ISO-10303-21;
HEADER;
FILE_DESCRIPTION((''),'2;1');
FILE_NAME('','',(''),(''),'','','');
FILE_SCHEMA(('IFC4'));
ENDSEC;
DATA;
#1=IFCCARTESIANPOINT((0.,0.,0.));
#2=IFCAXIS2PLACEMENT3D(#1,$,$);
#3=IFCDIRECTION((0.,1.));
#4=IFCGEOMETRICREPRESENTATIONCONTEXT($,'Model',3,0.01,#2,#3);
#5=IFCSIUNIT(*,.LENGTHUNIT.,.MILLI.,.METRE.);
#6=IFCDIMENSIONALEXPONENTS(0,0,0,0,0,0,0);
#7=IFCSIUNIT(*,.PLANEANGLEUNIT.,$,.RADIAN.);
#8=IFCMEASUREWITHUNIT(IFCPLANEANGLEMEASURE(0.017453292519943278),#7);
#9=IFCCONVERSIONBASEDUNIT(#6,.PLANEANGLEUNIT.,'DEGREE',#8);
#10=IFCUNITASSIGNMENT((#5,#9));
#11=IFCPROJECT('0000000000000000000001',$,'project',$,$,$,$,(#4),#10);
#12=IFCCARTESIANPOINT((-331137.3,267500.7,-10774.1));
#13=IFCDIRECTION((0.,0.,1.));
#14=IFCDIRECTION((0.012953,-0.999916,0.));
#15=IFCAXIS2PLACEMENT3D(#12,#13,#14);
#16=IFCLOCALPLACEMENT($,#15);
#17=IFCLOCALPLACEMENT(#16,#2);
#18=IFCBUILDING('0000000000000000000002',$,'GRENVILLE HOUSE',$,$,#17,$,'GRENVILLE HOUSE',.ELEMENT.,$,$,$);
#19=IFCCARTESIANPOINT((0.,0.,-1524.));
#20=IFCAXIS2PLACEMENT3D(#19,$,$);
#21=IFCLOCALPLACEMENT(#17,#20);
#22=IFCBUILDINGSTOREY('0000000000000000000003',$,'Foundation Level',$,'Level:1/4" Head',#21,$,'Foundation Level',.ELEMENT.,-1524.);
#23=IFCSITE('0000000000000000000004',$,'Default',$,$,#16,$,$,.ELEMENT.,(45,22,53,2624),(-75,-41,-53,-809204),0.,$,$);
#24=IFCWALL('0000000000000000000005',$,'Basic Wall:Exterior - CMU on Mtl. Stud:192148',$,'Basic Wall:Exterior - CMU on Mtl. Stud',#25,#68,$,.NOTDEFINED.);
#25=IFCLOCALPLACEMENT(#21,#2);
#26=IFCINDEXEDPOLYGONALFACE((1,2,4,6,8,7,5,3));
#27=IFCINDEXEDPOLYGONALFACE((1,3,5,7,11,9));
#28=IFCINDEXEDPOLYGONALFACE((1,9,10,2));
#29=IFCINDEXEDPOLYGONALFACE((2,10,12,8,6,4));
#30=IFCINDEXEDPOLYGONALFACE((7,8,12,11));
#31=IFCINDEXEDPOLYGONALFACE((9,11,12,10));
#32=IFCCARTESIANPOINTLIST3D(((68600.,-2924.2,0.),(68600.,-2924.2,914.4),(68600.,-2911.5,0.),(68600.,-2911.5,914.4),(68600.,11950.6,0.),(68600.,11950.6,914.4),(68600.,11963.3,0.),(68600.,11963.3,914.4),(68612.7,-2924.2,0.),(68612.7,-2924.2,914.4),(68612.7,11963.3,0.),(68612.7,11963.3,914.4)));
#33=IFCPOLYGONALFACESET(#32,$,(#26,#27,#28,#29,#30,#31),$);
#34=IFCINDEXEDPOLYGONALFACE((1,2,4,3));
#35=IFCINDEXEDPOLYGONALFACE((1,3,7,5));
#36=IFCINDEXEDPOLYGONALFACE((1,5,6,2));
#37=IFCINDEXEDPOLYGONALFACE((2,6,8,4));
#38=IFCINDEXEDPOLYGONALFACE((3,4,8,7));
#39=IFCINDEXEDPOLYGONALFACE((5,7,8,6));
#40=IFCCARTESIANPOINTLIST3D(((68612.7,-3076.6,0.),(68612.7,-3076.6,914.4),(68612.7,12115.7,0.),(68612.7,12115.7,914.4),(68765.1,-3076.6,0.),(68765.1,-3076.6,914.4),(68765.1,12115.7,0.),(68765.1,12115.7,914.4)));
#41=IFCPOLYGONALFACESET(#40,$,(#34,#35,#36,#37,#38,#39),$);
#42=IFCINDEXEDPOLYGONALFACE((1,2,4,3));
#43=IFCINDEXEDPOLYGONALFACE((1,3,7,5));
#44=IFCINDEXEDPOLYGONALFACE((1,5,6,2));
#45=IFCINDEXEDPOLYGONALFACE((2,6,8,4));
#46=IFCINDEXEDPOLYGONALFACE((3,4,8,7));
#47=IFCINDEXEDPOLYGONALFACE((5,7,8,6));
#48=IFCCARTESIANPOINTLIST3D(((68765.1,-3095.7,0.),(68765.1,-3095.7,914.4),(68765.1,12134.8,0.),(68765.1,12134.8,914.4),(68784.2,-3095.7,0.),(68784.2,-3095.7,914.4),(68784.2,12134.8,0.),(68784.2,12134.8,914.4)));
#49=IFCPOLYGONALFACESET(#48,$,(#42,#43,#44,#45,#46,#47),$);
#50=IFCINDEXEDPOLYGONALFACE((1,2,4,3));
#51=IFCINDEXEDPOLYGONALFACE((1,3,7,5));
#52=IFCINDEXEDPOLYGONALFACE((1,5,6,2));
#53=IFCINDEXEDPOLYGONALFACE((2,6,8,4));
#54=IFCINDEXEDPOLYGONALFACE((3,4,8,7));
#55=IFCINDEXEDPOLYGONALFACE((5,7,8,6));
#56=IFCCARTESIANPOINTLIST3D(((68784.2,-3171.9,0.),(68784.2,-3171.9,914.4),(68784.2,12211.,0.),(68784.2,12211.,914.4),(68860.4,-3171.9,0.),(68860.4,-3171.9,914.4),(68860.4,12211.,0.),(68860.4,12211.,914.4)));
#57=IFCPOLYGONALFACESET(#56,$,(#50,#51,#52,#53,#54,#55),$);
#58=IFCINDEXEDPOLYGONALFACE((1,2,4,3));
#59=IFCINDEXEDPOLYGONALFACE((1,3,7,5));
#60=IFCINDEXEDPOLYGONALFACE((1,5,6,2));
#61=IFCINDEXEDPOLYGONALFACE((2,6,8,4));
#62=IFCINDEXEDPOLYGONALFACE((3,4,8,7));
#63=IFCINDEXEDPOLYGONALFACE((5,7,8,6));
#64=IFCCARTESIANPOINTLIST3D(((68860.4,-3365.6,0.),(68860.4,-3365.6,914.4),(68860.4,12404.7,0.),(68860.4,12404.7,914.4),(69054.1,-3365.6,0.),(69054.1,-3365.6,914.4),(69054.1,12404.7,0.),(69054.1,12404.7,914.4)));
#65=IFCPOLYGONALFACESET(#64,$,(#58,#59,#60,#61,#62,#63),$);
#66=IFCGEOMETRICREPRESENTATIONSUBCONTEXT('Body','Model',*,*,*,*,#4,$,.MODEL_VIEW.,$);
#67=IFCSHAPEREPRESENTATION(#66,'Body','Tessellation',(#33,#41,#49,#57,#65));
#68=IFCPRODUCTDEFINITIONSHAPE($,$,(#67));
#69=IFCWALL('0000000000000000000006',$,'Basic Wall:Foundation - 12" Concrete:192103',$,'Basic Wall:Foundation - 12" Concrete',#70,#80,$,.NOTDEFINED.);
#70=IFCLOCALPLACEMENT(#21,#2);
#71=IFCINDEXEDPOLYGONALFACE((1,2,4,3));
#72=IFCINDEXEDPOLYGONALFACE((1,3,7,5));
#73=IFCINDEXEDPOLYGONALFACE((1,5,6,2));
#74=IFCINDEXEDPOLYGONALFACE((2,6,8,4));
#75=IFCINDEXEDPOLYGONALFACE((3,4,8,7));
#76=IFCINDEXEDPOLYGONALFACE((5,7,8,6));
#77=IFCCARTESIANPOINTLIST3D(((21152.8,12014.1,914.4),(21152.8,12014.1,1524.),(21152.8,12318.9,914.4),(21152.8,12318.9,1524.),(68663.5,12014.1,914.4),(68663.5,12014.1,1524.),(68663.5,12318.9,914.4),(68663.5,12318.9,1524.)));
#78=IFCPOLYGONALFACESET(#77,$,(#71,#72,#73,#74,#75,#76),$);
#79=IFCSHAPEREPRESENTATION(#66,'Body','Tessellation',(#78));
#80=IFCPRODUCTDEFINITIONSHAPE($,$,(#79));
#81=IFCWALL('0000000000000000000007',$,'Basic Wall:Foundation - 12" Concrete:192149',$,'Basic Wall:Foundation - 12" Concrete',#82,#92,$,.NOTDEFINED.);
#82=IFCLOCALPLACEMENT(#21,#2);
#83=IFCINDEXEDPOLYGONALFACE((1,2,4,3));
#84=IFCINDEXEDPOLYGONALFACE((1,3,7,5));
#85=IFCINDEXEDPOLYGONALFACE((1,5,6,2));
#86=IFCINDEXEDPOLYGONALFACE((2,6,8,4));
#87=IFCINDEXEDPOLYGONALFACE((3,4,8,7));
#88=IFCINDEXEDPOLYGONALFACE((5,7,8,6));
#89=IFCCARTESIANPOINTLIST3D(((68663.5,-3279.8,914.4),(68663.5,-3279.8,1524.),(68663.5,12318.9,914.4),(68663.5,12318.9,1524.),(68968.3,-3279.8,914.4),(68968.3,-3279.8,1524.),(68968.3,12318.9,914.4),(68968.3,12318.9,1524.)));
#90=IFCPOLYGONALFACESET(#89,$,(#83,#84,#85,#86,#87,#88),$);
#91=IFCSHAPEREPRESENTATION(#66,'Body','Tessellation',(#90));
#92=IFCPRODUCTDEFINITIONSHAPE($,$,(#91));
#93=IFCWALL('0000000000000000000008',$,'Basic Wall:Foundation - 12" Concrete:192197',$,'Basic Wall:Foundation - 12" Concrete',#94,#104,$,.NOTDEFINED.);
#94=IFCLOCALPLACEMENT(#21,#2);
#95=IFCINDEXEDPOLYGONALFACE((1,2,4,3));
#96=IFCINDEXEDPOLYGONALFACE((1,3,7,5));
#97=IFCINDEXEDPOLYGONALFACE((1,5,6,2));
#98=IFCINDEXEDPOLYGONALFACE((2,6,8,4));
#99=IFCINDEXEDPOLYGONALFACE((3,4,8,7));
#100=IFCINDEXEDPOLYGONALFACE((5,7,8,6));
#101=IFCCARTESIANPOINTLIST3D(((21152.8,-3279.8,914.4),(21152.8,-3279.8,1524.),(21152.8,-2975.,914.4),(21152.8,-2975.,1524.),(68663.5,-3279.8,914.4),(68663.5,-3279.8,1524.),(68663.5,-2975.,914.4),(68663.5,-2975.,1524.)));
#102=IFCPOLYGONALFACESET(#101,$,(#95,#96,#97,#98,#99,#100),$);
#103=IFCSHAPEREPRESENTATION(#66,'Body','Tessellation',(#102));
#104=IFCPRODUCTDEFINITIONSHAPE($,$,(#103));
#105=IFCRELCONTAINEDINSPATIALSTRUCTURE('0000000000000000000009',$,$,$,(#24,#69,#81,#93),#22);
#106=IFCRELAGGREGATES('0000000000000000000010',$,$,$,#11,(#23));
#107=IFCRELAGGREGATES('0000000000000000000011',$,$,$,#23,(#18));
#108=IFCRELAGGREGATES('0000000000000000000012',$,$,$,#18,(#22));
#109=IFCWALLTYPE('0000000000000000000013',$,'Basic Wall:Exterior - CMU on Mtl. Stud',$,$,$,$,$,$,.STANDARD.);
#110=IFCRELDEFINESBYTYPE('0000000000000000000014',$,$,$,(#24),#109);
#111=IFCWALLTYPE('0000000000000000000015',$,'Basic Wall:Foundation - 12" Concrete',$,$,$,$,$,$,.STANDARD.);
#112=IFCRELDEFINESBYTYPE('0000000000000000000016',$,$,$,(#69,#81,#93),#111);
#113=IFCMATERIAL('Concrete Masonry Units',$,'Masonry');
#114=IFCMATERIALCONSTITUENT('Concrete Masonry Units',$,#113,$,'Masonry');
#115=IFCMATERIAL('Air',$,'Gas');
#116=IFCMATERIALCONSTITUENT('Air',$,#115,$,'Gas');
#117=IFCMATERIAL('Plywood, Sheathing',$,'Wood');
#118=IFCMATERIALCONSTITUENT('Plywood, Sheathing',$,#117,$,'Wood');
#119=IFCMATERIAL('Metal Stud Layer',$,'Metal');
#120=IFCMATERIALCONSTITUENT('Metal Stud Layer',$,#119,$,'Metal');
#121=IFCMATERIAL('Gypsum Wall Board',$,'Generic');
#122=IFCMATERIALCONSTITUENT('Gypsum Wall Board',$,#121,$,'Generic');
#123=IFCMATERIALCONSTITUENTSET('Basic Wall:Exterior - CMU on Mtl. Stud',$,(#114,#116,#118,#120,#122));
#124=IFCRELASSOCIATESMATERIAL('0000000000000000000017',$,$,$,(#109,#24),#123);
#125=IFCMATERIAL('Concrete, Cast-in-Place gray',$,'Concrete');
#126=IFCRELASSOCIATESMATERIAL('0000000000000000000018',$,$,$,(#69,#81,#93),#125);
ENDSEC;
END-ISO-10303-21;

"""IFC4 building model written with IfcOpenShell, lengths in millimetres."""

from ifc_helpers import new_model, entity, si_unit, converted_unit, direction, frame, origin, place, context, subcontext, project, spatial, indexed_curve, outline, extrude, material, constituent, constituent_set, type_object, element, save


model = new_model("IFC4")

# Units and contexts
model_context = context("Model", 3, precision=0.01, world=origin(), true_north=direction((0.0, 1.0)))
body_context = subcontext(model_context, "Body", "Model", "MODEL_VIEW")
ifc_project = project(units=[si_unit("LENGTHUNIT", "METRE", prefix="MILLI"), converted_unit("PLANEANGLEUNIT", "DEGREE", entity("IfcPlaneAngleMeasure", 0.017453292519943278), si_unit("PLANEANGLEUNIT", "RADIAN"), dimensions=[0, 0, 0, 0, 0, 0, 0])], contexts=[model_context])

# Site, building, storey
site_placement = place(None, frame((-331137.3, 267500.7, -10774.1), z_axis=(0.0, 0.0, 1.0), x_axis=(0.012953, -0.999916, 0.0)))
site = spatial("IfcSite", under=ifc_project, at=site_placement, Name="Default", CompositionType="ELEMENT", RefLatitude=(45, 22, 53, 2624), RefLongitude=(-75, -41, -53, -809204), RefElevation=0.0)
building_placement = place(site_placement, origin())
building = spatial("IfcBuilding", under=site, at=building_placement, Name="GRENVILLE HOUSE", LongName="GRENVILLE HOUSE", CompositionType="ELEMENT")
storey_placement = place(building_placement, frame((0.0, 0.0, -1524.0)))
storey = spatial("IfcBuildingStorey", under=building, at=storey_placement, Name="Foundation Level", ObjectType="Level:1/4\" Head", LongName="Foundation Level", CompositionType="ELEMENT", Elevation=-1524.0)

# Shared definitions
ifc_material_1 = material(Name="Concrete, Cast-in-Place gray", Category="Concrete")

# Shared definitions
ifc_material_2 = material(Name="Concrete Masonry Units", Category="Masonry")
ifc_constituent_1 = constituent(ifc_material_2, Name="Concrete Masonry Units", Category="Masonry")
ifc_material_3 = material(Name="Air", Category="Gas")
ifc_constituent_2 = constituent(ifc_material_3, Name="Air", Category="Gas")
ifc_material_4 = material(Name="Plywood, Sheathing", Category="Wood")
ifc_constituent_3 = constituent(ifc_material_4, Name="Plywood, Sheathing", Category="Wood")
ifc_material_5 = material(Name="Metal Stud Layer", Category="Metal")
ifc_constituent_4 = constituent(ifc_material_5, Name="Metal Stud Layer", Category="Metal")
ifc_material_6 = material(Name="Gypsum Wall Board", Category="Generic")
ifc_constituent_5 = constituent(ifc_material_6, Name="Gypsum Wall Board", Category="Generic")
ifc_constituent_set = constituent_set(constituents=[ifc_constituent_1, ifc_constituent_2, ifc_constituent_3, ifc_constituent_4, ifc_constituent_5], Name="Basic Wall:Exterior - CMU on Mtl. Stud")
wall_type_1 = type_object("IfcWallType", Name="Basic Wall:Exterior - CMU on Mtl. Stud", PredefinedType="STANDARD", material=ifc_constituent_set)

# Walls
wall_1_placement = place(storey_placement, frame((68827.0, 12404.7, 0.0), z_axis=(0.0, 0.0, 1.0), x_axis=(0.0, -1.0, 0.0)))
element("IfcWall", 1, at=wall_1_placement, inside=storey, type_object=wall_type_1, material=ifc_constituent_set, Name="Basic Wall:Exterior - CMU on Mtl. Stud:192148", ObjectType="Basic Wall:Exterior - CMU on Mtl. Stud", PredefinedType="NOTDEFINED", context=body_context, shape_type="SweptSolid", body=[
    extrude(outline(indexed_curve([(-7431.1, -4.2), (7431.1, -4.2), (7443.8, -4.2), (7443.8, 8.5), (-7443.8, 8.5), (-7443.8, -4.2), (-7431.1, -4.2)], self_intersect=False)), frame((7885.1, -222.8, 0.0)), (0.0, 0.0, 1.0), 914.4),
    extrude(outline(indexed_curve([(-7596.2, -76.2), (7596.2, -76.2), (7596.2, 76.2), (-7596.2, 76.2), (-7596.2, -76.2)], self_intersect=False)), frame((7885.1, -138.1, 0.0)), (0.0, 0.0, 1.0), 914.4),
    extrude(outline(indexed_curve([(-7615.2, -9.5), (7615.2, -9.5), (7615.2, 9.5), (-7615.2, 9.5), (-7615.2, -9.5)], self_intersect=False)), frame((7885.1, -52.4, 0.0)), (0.0, 0.0, 1.0), 914.4),
    extrude(outline(indexed_curve([(-7691.4, -38.1), (7691.4, -38.1), (7691.4, 38.1), (-7691.4, 38.1), (-7691.4, -38.1)], self_intersect=False)), frame((7885.1, -4.8, 0.0)), (0.0, 0.0, 1.0), 914.4),
    extrude(outline(indexed_curve([(-96.8, -7885.1), (96.8, -7885.1), (96.8, 7885.1), (-96.8, 7885.1), (-96.8, -7885.1)], self_intersect=False)), frame((7885.1, 130.2, 0.0), z_axis=(0.0, 0.0, 1.0), x_axis=(0.0, -1.0, 0.0)), (0.0, 0.0, 1.0), 914.4),
])
wall_type_2 = type_object("IfcWallType", Name="Basic Wall:Foundation - 12\" Concrete", PredefinedType="STANDARD")
wall_2_placement = place(storey_placement, frame((21152.8, 12166.5, 914.4)))
element("IfcWall", 2, at=wall_2_placement, inside=storey, type_object=wall_type_2, material=ifc_material_1, Name="Basic Wall:Foundation - 12\" Concrete:192103", ObjectType="Basic Wall:Foundation - 12\" Concrete", PredefinedType="NOTDEFINED", context=body_context, shape_type="SweptSolid", body=[
    extrude(outline(indexed_curve([(47510.7, 152.4), (0.0, 152.4), (0.0, -152.4), (47510.7, -152.4), (47510.7, 152.4)], self_intersect=False)), origin(), (0.0, 0.0, 1.0), 609.6),
])
wall_3_placement = place(storey_placement, frame((68815.9, 12318.9, 914.4), z_axis=(0.0, 0.0, 1.0), x_axis=(0.0, -1.0, 0.0)))
element("IfcWall", 3, at=wall_3_placement, inside=storey, type_object=wall_type_2, material=ifc_material_1, Name="Basic Wall:Foundation - 12\" Concrete:192149", ObjectType="Basic Wall:Foundation - 12\" Concrete", PredefinedType="NOTDEFINED", context=body_context, shape_type="SweptSolid", body=[
    extrude(outline(indexed_curve([(15598.8, 152.4), (0.0, 152.4), (0.0, -152.4), (15598.8, -152.4), (15598.8, 152.4)], self_intersect=False)), origin(), (0.0, 0.0, 1.0), 609.6),
])
wall_4_placement = place(storey_placement, frame((68663.5, -3127.4, 914.4), z_axis=(0.0, 0.0, 1.0), x_axis=(-1.0, 0.0, 0.0)))
element("IfcWall", 4, at=wall_4_placement, inside=storey, type_object=wall_type_2, material=ifc_material_1, Name="Basic Wall:Foundation - 12\" Concrete:192197", ObjectType="Basic Wall:Foundation - 12\" Concrete", PredefinedType="NOTDEFINED", context=body_context, shape_type="SweptSolid", body=[
    extrude(outline(indexed_curve([(47510.7, 152.4), (0.0, 152.4), (0.0, -152.4), (47510.7, -152.4), (47510.7, 152.4)], self_intersect=False)), origin(), (0.0, 0.0, 1.0), 609.6),
])

save(model, "model.ifc")
